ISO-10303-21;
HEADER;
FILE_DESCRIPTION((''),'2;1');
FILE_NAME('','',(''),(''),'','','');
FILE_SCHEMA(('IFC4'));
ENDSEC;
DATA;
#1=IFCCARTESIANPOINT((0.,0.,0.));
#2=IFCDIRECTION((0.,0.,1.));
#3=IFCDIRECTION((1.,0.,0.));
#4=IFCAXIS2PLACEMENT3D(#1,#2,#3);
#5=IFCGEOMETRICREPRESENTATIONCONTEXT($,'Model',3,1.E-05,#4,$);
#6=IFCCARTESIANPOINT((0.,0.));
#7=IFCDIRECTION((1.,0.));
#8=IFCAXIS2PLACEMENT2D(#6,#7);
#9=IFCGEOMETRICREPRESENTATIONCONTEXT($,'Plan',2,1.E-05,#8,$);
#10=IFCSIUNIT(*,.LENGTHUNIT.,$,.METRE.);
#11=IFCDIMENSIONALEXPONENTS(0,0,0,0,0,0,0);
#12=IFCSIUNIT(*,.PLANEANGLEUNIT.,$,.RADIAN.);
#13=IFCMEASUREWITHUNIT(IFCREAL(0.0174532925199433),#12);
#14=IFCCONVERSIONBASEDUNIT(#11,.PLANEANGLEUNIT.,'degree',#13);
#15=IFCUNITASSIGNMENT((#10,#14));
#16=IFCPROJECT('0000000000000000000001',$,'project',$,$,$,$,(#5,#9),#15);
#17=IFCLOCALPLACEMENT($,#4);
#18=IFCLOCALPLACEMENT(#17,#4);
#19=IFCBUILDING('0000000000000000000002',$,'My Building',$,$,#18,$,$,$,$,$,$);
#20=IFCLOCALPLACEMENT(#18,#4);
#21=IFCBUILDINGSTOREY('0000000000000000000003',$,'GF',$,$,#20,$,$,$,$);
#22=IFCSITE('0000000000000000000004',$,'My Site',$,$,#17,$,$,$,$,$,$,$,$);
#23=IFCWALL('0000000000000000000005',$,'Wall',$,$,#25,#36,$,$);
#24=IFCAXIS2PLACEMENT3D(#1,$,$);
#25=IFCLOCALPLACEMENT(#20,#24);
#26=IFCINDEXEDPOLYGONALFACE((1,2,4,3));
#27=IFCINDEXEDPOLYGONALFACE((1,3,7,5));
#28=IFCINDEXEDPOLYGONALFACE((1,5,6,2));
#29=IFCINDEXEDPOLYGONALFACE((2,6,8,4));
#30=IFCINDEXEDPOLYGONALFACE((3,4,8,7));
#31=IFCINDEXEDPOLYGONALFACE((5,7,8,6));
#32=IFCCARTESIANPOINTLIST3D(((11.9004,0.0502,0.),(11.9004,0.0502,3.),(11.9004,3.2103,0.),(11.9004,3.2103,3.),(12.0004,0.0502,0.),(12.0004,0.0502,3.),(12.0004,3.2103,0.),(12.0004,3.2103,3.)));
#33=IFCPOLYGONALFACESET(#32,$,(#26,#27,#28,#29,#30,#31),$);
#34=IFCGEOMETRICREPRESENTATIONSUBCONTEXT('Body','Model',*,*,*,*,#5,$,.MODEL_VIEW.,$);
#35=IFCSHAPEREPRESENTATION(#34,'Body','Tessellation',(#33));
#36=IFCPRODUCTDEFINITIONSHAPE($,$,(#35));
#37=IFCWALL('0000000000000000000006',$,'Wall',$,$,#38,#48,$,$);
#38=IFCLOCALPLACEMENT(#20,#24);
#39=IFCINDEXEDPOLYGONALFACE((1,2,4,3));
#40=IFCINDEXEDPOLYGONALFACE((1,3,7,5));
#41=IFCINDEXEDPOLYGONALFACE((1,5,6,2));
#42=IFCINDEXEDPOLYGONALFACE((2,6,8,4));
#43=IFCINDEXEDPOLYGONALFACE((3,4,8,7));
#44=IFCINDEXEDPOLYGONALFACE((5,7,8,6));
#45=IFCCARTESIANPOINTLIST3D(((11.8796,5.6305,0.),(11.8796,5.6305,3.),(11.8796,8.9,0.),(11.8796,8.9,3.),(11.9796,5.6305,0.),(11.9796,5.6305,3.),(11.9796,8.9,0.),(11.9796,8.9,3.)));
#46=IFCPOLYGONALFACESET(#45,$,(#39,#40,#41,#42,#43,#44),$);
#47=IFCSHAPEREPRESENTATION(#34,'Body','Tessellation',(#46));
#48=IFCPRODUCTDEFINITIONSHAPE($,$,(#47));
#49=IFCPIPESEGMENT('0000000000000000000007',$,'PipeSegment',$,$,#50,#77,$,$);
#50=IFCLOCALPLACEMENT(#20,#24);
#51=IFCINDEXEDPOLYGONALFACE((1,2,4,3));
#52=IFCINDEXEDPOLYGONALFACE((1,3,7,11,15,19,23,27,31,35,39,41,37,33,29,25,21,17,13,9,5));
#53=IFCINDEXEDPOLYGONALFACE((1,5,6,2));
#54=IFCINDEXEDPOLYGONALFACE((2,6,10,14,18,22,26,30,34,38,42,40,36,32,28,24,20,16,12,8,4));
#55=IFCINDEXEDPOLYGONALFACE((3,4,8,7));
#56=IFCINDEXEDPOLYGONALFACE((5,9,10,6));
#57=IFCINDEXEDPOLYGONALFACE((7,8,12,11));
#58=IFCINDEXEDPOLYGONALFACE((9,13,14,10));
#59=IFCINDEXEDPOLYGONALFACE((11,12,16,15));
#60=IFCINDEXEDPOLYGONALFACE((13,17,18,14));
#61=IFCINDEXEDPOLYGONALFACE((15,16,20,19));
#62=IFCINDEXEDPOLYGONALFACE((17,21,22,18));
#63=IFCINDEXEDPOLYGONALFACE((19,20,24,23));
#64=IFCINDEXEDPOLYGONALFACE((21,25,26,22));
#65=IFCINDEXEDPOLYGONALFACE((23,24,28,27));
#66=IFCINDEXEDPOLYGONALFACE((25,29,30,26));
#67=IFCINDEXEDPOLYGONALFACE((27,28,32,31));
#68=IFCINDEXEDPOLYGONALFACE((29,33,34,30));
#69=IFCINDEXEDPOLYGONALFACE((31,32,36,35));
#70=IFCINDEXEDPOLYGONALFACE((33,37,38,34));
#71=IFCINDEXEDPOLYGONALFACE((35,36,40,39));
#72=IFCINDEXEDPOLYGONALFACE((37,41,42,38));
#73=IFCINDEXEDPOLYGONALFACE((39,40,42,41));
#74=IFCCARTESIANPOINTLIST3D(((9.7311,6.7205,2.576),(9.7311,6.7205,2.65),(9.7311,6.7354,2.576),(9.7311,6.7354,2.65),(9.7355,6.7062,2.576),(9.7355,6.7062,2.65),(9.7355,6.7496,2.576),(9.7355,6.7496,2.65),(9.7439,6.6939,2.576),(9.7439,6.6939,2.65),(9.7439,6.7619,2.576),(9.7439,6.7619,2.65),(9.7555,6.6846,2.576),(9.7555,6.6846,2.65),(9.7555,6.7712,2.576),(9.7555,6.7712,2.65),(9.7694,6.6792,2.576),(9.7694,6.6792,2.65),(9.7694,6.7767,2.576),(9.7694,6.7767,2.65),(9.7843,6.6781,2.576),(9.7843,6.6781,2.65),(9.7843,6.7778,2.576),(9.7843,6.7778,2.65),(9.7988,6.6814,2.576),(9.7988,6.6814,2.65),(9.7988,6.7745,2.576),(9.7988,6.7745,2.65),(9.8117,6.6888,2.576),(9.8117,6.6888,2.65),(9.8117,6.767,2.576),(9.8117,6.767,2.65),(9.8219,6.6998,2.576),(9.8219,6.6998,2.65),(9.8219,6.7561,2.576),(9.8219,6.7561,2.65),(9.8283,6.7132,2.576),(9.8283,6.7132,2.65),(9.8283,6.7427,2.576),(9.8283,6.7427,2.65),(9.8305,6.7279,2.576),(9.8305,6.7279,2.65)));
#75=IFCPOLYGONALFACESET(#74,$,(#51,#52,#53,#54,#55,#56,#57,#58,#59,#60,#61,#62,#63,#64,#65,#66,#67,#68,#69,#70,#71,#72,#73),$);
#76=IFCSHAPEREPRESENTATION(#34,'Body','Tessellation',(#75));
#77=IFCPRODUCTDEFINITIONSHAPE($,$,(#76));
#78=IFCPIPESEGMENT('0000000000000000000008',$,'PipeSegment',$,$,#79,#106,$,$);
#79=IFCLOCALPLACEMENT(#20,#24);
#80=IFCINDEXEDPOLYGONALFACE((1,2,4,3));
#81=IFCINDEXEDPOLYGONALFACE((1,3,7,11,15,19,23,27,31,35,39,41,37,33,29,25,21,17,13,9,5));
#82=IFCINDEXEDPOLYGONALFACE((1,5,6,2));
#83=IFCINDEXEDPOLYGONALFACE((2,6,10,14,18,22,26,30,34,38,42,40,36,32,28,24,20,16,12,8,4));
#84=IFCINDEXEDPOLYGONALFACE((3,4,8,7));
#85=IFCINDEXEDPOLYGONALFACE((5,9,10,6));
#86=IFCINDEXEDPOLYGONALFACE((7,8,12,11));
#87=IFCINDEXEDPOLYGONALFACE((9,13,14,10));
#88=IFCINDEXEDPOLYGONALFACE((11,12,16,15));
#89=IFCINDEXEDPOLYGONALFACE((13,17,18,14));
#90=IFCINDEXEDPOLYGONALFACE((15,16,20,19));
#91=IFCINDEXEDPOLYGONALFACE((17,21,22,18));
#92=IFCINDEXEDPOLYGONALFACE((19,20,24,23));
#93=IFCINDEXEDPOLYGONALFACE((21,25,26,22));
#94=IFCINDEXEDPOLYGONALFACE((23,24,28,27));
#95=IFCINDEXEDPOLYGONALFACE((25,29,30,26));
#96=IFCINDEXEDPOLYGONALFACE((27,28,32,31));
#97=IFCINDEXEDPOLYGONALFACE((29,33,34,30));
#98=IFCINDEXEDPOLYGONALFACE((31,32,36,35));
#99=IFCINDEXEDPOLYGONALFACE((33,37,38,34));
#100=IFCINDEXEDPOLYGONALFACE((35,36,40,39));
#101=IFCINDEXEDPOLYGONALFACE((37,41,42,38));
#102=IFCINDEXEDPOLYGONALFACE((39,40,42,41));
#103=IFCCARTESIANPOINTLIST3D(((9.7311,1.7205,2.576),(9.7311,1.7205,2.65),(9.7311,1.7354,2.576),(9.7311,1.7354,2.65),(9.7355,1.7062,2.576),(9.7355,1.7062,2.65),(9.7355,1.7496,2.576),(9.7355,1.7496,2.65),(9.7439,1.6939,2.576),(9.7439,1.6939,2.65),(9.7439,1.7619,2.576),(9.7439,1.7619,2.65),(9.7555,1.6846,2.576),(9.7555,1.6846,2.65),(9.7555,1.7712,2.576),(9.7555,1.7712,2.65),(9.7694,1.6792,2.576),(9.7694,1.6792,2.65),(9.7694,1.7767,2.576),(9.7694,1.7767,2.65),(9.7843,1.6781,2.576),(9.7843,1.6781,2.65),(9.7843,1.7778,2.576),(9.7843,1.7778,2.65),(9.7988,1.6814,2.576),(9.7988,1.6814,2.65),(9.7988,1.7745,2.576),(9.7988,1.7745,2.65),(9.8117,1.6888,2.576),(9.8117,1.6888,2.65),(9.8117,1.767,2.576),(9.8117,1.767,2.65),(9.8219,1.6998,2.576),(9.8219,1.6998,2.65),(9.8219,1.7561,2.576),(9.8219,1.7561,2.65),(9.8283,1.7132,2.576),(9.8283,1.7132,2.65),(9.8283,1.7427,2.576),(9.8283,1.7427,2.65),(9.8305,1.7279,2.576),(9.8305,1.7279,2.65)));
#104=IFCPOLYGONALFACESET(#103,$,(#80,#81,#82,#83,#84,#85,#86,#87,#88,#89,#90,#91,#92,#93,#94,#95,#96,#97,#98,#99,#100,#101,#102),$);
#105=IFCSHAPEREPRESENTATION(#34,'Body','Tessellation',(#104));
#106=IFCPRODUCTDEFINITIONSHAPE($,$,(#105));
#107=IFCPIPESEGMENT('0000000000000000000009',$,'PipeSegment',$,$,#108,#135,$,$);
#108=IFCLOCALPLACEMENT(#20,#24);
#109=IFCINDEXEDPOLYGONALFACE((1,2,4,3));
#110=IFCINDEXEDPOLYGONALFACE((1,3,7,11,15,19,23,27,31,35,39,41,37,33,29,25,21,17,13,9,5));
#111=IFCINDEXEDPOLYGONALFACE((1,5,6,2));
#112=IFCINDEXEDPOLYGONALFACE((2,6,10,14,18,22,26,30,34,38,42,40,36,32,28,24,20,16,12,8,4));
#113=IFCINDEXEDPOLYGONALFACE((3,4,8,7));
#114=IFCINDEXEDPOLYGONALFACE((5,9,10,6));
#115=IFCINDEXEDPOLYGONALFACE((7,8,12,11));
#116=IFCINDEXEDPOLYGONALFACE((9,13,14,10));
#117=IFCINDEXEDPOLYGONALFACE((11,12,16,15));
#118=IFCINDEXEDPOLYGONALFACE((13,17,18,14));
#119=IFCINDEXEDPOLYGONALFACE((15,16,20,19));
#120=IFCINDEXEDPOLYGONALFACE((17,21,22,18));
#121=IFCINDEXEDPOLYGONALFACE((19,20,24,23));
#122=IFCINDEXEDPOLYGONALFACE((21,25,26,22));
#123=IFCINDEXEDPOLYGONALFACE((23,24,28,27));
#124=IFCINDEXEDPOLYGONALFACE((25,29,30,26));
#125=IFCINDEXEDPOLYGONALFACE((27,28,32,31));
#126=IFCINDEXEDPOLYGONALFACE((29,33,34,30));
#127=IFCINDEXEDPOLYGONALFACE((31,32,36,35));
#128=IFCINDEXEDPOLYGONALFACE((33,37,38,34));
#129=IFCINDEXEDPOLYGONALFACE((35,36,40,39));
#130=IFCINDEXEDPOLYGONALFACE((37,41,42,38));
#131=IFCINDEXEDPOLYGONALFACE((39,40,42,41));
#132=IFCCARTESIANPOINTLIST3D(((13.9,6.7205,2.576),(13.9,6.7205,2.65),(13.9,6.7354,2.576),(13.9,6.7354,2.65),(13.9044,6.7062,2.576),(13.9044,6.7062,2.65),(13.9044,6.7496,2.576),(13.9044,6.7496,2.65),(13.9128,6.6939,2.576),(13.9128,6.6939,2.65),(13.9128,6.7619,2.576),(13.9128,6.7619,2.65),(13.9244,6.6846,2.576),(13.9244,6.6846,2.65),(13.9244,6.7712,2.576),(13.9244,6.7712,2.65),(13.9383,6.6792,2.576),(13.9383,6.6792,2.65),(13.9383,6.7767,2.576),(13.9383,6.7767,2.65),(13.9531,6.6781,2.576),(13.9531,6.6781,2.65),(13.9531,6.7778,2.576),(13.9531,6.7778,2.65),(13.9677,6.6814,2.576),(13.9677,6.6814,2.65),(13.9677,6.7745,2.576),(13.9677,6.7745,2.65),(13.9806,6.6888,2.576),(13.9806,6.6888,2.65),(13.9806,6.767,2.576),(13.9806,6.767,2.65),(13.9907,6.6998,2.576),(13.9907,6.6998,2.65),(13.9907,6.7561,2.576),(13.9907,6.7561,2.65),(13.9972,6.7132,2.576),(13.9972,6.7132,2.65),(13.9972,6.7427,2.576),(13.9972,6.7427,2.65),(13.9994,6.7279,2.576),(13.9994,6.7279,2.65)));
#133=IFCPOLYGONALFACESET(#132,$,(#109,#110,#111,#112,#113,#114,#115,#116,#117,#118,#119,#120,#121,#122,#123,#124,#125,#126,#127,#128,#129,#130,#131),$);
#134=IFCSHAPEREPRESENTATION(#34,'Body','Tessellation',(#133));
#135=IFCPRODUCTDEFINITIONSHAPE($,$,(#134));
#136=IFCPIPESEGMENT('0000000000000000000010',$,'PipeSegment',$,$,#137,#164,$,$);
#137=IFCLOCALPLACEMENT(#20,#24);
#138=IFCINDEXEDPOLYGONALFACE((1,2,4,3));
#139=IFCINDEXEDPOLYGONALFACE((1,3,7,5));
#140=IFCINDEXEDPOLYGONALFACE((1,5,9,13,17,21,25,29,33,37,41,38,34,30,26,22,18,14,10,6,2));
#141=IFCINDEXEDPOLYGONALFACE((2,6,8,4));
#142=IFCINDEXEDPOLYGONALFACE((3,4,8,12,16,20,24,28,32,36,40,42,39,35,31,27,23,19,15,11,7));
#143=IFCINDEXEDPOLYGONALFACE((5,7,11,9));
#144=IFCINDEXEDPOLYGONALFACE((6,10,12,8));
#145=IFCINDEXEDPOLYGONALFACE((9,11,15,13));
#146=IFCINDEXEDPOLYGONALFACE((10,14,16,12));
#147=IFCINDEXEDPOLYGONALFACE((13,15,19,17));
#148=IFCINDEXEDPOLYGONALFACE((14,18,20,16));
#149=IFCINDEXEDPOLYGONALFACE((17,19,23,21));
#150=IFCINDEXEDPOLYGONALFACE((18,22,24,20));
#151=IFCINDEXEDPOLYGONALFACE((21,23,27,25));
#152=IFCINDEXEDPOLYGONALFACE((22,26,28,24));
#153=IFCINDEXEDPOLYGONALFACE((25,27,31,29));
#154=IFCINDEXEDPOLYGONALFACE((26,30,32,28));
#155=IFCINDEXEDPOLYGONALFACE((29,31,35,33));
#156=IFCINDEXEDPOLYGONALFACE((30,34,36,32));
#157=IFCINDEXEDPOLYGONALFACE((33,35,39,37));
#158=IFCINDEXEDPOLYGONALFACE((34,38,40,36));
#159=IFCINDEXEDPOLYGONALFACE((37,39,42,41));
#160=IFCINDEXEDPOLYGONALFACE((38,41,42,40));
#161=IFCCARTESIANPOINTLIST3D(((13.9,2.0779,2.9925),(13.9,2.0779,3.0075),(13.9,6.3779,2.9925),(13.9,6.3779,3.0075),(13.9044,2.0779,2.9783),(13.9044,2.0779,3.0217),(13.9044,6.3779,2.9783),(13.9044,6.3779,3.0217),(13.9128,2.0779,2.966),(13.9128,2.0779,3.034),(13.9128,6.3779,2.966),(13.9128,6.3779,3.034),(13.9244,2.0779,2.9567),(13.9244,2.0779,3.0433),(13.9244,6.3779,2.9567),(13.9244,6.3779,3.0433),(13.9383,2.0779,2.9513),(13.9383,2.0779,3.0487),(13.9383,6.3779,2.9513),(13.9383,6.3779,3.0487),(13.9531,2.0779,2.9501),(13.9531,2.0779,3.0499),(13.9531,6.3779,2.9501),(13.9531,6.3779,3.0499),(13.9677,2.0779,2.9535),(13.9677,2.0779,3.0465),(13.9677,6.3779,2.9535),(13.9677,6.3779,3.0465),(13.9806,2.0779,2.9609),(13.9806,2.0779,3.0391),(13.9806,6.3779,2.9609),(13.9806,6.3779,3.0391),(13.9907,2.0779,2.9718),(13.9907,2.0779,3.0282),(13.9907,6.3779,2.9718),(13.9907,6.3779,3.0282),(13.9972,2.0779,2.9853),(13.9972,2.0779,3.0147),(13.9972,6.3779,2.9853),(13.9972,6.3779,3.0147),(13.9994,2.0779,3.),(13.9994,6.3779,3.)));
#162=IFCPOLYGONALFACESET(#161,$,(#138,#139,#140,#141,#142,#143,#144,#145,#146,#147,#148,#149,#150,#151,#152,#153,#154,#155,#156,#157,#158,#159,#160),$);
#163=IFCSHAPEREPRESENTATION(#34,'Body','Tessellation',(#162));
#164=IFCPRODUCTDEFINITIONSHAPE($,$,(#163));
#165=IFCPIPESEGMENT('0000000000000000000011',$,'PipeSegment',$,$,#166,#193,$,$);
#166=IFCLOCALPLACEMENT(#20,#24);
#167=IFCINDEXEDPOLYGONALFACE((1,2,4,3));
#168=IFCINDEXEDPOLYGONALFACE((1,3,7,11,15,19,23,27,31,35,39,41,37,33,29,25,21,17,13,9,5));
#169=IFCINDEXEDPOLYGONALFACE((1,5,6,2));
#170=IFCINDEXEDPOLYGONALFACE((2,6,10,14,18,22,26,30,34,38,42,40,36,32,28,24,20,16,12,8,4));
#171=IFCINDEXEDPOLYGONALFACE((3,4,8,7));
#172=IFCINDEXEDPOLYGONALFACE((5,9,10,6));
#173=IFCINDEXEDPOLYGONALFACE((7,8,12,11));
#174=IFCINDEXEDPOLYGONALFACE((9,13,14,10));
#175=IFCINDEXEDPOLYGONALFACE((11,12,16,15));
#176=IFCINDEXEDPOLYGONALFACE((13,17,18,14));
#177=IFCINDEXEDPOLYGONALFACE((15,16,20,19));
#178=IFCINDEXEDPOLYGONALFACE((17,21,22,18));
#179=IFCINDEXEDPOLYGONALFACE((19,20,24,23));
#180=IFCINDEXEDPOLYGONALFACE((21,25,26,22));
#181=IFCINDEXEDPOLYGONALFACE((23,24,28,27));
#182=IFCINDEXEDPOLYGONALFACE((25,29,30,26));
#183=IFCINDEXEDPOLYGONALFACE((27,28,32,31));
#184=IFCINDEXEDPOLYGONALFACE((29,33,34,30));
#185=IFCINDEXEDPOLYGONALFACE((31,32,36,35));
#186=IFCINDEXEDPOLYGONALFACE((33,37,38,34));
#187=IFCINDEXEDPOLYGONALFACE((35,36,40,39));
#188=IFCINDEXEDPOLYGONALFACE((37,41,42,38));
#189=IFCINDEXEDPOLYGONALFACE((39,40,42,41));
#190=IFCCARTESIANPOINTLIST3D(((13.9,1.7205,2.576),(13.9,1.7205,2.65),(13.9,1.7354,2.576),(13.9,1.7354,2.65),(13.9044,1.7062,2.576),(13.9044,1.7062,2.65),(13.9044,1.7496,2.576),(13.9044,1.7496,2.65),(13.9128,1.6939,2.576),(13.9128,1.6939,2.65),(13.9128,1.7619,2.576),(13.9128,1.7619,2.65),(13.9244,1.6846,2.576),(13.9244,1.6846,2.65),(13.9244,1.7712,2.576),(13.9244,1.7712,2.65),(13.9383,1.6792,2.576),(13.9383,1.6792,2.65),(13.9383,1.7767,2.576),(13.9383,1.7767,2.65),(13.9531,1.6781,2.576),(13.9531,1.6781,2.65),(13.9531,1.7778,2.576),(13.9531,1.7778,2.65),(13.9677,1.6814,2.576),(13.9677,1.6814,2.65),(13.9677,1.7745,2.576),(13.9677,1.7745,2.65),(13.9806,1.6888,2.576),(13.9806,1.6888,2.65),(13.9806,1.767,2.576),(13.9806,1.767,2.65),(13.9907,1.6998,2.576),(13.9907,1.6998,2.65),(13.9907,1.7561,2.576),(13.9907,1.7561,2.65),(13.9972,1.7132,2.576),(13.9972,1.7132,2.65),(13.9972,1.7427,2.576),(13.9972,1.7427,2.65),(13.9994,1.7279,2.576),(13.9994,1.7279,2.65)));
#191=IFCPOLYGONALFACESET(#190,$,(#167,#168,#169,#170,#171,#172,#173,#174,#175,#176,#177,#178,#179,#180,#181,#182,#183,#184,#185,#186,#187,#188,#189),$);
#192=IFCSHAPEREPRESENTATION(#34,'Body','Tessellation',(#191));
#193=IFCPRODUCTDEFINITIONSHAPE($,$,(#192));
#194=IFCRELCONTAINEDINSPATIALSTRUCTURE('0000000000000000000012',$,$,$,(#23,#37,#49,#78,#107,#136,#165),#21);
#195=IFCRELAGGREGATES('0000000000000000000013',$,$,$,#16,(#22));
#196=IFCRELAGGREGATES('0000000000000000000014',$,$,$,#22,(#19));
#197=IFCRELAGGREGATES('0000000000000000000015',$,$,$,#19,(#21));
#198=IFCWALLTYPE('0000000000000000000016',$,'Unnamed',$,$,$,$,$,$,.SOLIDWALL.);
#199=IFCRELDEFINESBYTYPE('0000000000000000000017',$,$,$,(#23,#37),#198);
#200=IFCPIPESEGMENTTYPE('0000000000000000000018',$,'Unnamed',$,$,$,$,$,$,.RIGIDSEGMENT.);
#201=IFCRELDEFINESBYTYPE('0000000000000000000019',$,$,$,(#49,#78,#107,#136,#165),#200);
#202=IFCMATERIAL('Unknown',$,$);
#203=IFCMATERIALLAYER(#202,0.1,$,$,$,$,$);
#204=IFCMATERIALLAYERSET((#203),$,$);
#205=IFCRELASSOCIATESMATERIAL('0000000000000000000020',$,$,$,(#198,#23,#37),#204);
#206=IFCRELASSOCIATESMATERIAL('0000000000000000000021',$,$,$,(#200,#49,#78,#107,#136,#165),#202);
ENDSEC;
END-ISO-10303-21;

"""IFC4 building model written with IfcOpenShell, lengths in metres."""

from ifc_helpers import new_model, entity, si_unit, converted_unit, frame, origin_with_axes, origin_2d_with_axis, place, context, subcontext, project, spatial, line, indexed_curve, circle, outline, extrude, material, layer, layer_set, layer_usage, material_profile, profile_set, profile_usage, type_object, element, save


model = new_model("IFC4")

# Units and contexts
model_context = context("Model", 3, precision=1e-05, world=origin_with_axes())
plan_context = context("Plan", 2, precision=1e-05, world=origin_2d_with_axis())
body_context = subcontext(model_context, "Body", "Model", "MODEL_VIEW")
ifc_project = project(units=[si_unit("LENGTHUNIT", "METRE"), converted_unit("PLANEANGLEUNIT", "degree", entity("IfcReal", 0.0174532925199433), si_unit("PLANEANGLEUNIT", "RADIAN"), dimensions=[0, 0, 0, 0, 0, 0, 0])], contexts=[model_context, plan_context])

# Site, building, storey
site_placement = place(None, origin_with_axes())
site = spatial("IfcSite", under=ifc_project, at=site_placement, Name="My Site")
building_placement = place(site_placement, origin_with_axes())
building = spatial("IfcBuilding", under=site, at=building_placement, Name="My Building")
storey_placement = place(building_placement, origin_with_axes())
storey = spatial("IfcBuildingStorey", under=building, at=storey_placement, Name="GF")

# Walls
ifc_material = material(Name="Unknown")
ifc_layer = layer(ifc_material, 0.1)
ifc_layer_set = layer_set([ifc_layer])
ifc_layer_usage_1 = layer_usage(ifc_layer_set, "AXIS2", "POSITIVE", 0.0)
wall_type = type_object("IfcWallType", Name="Unnamed", PredefinedType="SOLIDWALL", material=ifc_layer_set)
wall_1_placement = place(storey_placement, frame((12.0004, 0.0502, 0.0), z_axis=(0.0, 0.0, 1.0), x_axis=(0.000013, 1.0, 0.0)))
element("IfcWall", 1, at=wall_1_placement, inside=storey, type_object=wall_type, material=ifc_layer_usage_1, Name="Wall", context=body_context, shape_type="SweptSolid", body=[
    extrude(outline(indexed_curve([(0.0, 0.0), (0.0, 0.1), (3.1602, 0.1), (3.1602, 0.0)], segments=[line(1, 2, 3, 4, 1)])), origin_with_axes(), (0.0, 0.0, 1.0), 3.0),
])
ifc_layer_usage_2 = layer_usage(ifc_layer_set, "AXIS2", "POSITIVE", 0.0)
wall_2_placement = place(storey_placement, frame((11.9796, 5.6305, 0.0), z_axis=(0.0, 0.0, 1.0), x_axis=(0.0, 1.0, 0.0)))
element("IfcWall", 2, at=wall_2_placement, inside=storey, type_object=wall_type, material=ifc_layer_usage_2, Name="Wall", context=body_context, shape_type="SweptSolid", body=[
    extrude(outline(indexed_curve([(0.0, 0.0), (0.0, 0.1), (3.2695, 0.1), (3.2695, 0.0)], segments=[line(1, 2, 3, 4, 1)])), origin_with_axes(), (0.0, 0.0, 1.0), 3.0),
])

# Pipe segments
ifc_material_profile = material_profile(ifc_material, circle(Radius=0.05))
ifc_profile_set = profile_set([ifc_material_profile])
ifc_profile_usage_1 = profile_usage(ifc_profile_set, cardinal=5)
pipe_segment_type = type_object("IfcPipeSegmentType", Name="Unnamed", PredefinedType="RIGIDSEGMENT", material=ifc_profile_set)
pipe_segment_1_placement = place(storey_placement, frame((9.7805, 6.7279, 2.576), z_axis=(0.0, 0.0, 1.0), x_axis=(1.0, 0.0, 0.0)))
element("IfcPipeSegment", 3, at=pipe_segment_1_placement, inside=storey, type_object=pipe_segment_type, material=ifc_profile_usage_1, Name="PipeSegment", context=body_context, shape_type="SweptSolid", body=[
    extrude(circle(Radius=0.05), origin_with_axes(), (0.0, 0.0, 1.0), 0.074),
])
ifc_profile_usage_2 = profile_usage(ifc_profile_set, cardinal=5)
pipe_segment_2_placement = place(storey_placement, frame((9.7805, 1.7279, 2.576), z_axis=(0.0, 0.0, 1.0), x_axis=(1.0, 0.0, 0.0)))
element("IfcPipeSegment", 4, at=pipe_segment_2_placement, inside=storey, type_object=pipe_segment_type, material=ifc_profile_usage_2, Name="PipeSegment", context=body_context, shape_type="SweptSolid", body=[
    extrude(circle(Radius=0.05), origin_with_axes(), (0.0, 0.0, 1.0), 0.074),
])
ifc_profile_usage_3 = profile_usage(ifc_profile_set, cardinal=5)
pipe_segment_3_placement = place(storey_placement, frame((13.9494, 6.7279, 2.576), z_axis=(0.0, 0.0, 1.0), x_axis=(1.0, 0.0, 0.0)))
element("IfcPipeSegment", 5, at=pipe_segment_3_placement, inside=storey, type_object=pipe_segment_type, material=ifc_profile_usage_3, Name="PipeSegment", context=body_context, shape_type="SweptSolid", body=[
    extrude(circle(Radius=0.05), origin_with_axes(), (0.0, 0.0, 1.0), 0.074),
])
ifc_profile_usage_4 = profile_usage(ifc_profile_set, cardinal=5)
pipe_segment_4_placement = place(storey_placement, frame((13.9494, 6.3779, 3.0), z_axis=(0.0, -1.0, 0.0), x_axis=(1.0, 0.0, 0.0)))
element("IfcPipeSegment", 6, at=pipe_segment_4_placement, inside=storey, type_object=pipe_segment_type, material=ifc_profile_usage_4, Name="PipeSegment", context=body_context, shape_type="SweptSolid", body=[
    extrude(circle(Radius=0.05), origin_with_axes(), (0.0, 0.0, 1.0), 4.3),
])
ifc_profile_usage_5 = profile_usage(ifc_profile_set, cardinal=5)
pipe_segment_5_placement = place(storey_placement, frame((13.9494, 1.7279, 2.576), z_axis=(0.0, 0.0, 1.0), x_axis=(1.0, 0.0, 0.0)))
element("IfcPipeSegment", 7, at=pipe_segment_5_placement, inside=storey, type_object=pipe_segment_type, material=ifc_profile_usage_5, Name="PipeSegment", context=body_context, shape_type="SweptSolid", body=[
    extrude(circle(Radius=0.05), origin_with_axes(), (0.0, 0.0, 1.0), 0.074),
])

save(model, "model.ifc")
